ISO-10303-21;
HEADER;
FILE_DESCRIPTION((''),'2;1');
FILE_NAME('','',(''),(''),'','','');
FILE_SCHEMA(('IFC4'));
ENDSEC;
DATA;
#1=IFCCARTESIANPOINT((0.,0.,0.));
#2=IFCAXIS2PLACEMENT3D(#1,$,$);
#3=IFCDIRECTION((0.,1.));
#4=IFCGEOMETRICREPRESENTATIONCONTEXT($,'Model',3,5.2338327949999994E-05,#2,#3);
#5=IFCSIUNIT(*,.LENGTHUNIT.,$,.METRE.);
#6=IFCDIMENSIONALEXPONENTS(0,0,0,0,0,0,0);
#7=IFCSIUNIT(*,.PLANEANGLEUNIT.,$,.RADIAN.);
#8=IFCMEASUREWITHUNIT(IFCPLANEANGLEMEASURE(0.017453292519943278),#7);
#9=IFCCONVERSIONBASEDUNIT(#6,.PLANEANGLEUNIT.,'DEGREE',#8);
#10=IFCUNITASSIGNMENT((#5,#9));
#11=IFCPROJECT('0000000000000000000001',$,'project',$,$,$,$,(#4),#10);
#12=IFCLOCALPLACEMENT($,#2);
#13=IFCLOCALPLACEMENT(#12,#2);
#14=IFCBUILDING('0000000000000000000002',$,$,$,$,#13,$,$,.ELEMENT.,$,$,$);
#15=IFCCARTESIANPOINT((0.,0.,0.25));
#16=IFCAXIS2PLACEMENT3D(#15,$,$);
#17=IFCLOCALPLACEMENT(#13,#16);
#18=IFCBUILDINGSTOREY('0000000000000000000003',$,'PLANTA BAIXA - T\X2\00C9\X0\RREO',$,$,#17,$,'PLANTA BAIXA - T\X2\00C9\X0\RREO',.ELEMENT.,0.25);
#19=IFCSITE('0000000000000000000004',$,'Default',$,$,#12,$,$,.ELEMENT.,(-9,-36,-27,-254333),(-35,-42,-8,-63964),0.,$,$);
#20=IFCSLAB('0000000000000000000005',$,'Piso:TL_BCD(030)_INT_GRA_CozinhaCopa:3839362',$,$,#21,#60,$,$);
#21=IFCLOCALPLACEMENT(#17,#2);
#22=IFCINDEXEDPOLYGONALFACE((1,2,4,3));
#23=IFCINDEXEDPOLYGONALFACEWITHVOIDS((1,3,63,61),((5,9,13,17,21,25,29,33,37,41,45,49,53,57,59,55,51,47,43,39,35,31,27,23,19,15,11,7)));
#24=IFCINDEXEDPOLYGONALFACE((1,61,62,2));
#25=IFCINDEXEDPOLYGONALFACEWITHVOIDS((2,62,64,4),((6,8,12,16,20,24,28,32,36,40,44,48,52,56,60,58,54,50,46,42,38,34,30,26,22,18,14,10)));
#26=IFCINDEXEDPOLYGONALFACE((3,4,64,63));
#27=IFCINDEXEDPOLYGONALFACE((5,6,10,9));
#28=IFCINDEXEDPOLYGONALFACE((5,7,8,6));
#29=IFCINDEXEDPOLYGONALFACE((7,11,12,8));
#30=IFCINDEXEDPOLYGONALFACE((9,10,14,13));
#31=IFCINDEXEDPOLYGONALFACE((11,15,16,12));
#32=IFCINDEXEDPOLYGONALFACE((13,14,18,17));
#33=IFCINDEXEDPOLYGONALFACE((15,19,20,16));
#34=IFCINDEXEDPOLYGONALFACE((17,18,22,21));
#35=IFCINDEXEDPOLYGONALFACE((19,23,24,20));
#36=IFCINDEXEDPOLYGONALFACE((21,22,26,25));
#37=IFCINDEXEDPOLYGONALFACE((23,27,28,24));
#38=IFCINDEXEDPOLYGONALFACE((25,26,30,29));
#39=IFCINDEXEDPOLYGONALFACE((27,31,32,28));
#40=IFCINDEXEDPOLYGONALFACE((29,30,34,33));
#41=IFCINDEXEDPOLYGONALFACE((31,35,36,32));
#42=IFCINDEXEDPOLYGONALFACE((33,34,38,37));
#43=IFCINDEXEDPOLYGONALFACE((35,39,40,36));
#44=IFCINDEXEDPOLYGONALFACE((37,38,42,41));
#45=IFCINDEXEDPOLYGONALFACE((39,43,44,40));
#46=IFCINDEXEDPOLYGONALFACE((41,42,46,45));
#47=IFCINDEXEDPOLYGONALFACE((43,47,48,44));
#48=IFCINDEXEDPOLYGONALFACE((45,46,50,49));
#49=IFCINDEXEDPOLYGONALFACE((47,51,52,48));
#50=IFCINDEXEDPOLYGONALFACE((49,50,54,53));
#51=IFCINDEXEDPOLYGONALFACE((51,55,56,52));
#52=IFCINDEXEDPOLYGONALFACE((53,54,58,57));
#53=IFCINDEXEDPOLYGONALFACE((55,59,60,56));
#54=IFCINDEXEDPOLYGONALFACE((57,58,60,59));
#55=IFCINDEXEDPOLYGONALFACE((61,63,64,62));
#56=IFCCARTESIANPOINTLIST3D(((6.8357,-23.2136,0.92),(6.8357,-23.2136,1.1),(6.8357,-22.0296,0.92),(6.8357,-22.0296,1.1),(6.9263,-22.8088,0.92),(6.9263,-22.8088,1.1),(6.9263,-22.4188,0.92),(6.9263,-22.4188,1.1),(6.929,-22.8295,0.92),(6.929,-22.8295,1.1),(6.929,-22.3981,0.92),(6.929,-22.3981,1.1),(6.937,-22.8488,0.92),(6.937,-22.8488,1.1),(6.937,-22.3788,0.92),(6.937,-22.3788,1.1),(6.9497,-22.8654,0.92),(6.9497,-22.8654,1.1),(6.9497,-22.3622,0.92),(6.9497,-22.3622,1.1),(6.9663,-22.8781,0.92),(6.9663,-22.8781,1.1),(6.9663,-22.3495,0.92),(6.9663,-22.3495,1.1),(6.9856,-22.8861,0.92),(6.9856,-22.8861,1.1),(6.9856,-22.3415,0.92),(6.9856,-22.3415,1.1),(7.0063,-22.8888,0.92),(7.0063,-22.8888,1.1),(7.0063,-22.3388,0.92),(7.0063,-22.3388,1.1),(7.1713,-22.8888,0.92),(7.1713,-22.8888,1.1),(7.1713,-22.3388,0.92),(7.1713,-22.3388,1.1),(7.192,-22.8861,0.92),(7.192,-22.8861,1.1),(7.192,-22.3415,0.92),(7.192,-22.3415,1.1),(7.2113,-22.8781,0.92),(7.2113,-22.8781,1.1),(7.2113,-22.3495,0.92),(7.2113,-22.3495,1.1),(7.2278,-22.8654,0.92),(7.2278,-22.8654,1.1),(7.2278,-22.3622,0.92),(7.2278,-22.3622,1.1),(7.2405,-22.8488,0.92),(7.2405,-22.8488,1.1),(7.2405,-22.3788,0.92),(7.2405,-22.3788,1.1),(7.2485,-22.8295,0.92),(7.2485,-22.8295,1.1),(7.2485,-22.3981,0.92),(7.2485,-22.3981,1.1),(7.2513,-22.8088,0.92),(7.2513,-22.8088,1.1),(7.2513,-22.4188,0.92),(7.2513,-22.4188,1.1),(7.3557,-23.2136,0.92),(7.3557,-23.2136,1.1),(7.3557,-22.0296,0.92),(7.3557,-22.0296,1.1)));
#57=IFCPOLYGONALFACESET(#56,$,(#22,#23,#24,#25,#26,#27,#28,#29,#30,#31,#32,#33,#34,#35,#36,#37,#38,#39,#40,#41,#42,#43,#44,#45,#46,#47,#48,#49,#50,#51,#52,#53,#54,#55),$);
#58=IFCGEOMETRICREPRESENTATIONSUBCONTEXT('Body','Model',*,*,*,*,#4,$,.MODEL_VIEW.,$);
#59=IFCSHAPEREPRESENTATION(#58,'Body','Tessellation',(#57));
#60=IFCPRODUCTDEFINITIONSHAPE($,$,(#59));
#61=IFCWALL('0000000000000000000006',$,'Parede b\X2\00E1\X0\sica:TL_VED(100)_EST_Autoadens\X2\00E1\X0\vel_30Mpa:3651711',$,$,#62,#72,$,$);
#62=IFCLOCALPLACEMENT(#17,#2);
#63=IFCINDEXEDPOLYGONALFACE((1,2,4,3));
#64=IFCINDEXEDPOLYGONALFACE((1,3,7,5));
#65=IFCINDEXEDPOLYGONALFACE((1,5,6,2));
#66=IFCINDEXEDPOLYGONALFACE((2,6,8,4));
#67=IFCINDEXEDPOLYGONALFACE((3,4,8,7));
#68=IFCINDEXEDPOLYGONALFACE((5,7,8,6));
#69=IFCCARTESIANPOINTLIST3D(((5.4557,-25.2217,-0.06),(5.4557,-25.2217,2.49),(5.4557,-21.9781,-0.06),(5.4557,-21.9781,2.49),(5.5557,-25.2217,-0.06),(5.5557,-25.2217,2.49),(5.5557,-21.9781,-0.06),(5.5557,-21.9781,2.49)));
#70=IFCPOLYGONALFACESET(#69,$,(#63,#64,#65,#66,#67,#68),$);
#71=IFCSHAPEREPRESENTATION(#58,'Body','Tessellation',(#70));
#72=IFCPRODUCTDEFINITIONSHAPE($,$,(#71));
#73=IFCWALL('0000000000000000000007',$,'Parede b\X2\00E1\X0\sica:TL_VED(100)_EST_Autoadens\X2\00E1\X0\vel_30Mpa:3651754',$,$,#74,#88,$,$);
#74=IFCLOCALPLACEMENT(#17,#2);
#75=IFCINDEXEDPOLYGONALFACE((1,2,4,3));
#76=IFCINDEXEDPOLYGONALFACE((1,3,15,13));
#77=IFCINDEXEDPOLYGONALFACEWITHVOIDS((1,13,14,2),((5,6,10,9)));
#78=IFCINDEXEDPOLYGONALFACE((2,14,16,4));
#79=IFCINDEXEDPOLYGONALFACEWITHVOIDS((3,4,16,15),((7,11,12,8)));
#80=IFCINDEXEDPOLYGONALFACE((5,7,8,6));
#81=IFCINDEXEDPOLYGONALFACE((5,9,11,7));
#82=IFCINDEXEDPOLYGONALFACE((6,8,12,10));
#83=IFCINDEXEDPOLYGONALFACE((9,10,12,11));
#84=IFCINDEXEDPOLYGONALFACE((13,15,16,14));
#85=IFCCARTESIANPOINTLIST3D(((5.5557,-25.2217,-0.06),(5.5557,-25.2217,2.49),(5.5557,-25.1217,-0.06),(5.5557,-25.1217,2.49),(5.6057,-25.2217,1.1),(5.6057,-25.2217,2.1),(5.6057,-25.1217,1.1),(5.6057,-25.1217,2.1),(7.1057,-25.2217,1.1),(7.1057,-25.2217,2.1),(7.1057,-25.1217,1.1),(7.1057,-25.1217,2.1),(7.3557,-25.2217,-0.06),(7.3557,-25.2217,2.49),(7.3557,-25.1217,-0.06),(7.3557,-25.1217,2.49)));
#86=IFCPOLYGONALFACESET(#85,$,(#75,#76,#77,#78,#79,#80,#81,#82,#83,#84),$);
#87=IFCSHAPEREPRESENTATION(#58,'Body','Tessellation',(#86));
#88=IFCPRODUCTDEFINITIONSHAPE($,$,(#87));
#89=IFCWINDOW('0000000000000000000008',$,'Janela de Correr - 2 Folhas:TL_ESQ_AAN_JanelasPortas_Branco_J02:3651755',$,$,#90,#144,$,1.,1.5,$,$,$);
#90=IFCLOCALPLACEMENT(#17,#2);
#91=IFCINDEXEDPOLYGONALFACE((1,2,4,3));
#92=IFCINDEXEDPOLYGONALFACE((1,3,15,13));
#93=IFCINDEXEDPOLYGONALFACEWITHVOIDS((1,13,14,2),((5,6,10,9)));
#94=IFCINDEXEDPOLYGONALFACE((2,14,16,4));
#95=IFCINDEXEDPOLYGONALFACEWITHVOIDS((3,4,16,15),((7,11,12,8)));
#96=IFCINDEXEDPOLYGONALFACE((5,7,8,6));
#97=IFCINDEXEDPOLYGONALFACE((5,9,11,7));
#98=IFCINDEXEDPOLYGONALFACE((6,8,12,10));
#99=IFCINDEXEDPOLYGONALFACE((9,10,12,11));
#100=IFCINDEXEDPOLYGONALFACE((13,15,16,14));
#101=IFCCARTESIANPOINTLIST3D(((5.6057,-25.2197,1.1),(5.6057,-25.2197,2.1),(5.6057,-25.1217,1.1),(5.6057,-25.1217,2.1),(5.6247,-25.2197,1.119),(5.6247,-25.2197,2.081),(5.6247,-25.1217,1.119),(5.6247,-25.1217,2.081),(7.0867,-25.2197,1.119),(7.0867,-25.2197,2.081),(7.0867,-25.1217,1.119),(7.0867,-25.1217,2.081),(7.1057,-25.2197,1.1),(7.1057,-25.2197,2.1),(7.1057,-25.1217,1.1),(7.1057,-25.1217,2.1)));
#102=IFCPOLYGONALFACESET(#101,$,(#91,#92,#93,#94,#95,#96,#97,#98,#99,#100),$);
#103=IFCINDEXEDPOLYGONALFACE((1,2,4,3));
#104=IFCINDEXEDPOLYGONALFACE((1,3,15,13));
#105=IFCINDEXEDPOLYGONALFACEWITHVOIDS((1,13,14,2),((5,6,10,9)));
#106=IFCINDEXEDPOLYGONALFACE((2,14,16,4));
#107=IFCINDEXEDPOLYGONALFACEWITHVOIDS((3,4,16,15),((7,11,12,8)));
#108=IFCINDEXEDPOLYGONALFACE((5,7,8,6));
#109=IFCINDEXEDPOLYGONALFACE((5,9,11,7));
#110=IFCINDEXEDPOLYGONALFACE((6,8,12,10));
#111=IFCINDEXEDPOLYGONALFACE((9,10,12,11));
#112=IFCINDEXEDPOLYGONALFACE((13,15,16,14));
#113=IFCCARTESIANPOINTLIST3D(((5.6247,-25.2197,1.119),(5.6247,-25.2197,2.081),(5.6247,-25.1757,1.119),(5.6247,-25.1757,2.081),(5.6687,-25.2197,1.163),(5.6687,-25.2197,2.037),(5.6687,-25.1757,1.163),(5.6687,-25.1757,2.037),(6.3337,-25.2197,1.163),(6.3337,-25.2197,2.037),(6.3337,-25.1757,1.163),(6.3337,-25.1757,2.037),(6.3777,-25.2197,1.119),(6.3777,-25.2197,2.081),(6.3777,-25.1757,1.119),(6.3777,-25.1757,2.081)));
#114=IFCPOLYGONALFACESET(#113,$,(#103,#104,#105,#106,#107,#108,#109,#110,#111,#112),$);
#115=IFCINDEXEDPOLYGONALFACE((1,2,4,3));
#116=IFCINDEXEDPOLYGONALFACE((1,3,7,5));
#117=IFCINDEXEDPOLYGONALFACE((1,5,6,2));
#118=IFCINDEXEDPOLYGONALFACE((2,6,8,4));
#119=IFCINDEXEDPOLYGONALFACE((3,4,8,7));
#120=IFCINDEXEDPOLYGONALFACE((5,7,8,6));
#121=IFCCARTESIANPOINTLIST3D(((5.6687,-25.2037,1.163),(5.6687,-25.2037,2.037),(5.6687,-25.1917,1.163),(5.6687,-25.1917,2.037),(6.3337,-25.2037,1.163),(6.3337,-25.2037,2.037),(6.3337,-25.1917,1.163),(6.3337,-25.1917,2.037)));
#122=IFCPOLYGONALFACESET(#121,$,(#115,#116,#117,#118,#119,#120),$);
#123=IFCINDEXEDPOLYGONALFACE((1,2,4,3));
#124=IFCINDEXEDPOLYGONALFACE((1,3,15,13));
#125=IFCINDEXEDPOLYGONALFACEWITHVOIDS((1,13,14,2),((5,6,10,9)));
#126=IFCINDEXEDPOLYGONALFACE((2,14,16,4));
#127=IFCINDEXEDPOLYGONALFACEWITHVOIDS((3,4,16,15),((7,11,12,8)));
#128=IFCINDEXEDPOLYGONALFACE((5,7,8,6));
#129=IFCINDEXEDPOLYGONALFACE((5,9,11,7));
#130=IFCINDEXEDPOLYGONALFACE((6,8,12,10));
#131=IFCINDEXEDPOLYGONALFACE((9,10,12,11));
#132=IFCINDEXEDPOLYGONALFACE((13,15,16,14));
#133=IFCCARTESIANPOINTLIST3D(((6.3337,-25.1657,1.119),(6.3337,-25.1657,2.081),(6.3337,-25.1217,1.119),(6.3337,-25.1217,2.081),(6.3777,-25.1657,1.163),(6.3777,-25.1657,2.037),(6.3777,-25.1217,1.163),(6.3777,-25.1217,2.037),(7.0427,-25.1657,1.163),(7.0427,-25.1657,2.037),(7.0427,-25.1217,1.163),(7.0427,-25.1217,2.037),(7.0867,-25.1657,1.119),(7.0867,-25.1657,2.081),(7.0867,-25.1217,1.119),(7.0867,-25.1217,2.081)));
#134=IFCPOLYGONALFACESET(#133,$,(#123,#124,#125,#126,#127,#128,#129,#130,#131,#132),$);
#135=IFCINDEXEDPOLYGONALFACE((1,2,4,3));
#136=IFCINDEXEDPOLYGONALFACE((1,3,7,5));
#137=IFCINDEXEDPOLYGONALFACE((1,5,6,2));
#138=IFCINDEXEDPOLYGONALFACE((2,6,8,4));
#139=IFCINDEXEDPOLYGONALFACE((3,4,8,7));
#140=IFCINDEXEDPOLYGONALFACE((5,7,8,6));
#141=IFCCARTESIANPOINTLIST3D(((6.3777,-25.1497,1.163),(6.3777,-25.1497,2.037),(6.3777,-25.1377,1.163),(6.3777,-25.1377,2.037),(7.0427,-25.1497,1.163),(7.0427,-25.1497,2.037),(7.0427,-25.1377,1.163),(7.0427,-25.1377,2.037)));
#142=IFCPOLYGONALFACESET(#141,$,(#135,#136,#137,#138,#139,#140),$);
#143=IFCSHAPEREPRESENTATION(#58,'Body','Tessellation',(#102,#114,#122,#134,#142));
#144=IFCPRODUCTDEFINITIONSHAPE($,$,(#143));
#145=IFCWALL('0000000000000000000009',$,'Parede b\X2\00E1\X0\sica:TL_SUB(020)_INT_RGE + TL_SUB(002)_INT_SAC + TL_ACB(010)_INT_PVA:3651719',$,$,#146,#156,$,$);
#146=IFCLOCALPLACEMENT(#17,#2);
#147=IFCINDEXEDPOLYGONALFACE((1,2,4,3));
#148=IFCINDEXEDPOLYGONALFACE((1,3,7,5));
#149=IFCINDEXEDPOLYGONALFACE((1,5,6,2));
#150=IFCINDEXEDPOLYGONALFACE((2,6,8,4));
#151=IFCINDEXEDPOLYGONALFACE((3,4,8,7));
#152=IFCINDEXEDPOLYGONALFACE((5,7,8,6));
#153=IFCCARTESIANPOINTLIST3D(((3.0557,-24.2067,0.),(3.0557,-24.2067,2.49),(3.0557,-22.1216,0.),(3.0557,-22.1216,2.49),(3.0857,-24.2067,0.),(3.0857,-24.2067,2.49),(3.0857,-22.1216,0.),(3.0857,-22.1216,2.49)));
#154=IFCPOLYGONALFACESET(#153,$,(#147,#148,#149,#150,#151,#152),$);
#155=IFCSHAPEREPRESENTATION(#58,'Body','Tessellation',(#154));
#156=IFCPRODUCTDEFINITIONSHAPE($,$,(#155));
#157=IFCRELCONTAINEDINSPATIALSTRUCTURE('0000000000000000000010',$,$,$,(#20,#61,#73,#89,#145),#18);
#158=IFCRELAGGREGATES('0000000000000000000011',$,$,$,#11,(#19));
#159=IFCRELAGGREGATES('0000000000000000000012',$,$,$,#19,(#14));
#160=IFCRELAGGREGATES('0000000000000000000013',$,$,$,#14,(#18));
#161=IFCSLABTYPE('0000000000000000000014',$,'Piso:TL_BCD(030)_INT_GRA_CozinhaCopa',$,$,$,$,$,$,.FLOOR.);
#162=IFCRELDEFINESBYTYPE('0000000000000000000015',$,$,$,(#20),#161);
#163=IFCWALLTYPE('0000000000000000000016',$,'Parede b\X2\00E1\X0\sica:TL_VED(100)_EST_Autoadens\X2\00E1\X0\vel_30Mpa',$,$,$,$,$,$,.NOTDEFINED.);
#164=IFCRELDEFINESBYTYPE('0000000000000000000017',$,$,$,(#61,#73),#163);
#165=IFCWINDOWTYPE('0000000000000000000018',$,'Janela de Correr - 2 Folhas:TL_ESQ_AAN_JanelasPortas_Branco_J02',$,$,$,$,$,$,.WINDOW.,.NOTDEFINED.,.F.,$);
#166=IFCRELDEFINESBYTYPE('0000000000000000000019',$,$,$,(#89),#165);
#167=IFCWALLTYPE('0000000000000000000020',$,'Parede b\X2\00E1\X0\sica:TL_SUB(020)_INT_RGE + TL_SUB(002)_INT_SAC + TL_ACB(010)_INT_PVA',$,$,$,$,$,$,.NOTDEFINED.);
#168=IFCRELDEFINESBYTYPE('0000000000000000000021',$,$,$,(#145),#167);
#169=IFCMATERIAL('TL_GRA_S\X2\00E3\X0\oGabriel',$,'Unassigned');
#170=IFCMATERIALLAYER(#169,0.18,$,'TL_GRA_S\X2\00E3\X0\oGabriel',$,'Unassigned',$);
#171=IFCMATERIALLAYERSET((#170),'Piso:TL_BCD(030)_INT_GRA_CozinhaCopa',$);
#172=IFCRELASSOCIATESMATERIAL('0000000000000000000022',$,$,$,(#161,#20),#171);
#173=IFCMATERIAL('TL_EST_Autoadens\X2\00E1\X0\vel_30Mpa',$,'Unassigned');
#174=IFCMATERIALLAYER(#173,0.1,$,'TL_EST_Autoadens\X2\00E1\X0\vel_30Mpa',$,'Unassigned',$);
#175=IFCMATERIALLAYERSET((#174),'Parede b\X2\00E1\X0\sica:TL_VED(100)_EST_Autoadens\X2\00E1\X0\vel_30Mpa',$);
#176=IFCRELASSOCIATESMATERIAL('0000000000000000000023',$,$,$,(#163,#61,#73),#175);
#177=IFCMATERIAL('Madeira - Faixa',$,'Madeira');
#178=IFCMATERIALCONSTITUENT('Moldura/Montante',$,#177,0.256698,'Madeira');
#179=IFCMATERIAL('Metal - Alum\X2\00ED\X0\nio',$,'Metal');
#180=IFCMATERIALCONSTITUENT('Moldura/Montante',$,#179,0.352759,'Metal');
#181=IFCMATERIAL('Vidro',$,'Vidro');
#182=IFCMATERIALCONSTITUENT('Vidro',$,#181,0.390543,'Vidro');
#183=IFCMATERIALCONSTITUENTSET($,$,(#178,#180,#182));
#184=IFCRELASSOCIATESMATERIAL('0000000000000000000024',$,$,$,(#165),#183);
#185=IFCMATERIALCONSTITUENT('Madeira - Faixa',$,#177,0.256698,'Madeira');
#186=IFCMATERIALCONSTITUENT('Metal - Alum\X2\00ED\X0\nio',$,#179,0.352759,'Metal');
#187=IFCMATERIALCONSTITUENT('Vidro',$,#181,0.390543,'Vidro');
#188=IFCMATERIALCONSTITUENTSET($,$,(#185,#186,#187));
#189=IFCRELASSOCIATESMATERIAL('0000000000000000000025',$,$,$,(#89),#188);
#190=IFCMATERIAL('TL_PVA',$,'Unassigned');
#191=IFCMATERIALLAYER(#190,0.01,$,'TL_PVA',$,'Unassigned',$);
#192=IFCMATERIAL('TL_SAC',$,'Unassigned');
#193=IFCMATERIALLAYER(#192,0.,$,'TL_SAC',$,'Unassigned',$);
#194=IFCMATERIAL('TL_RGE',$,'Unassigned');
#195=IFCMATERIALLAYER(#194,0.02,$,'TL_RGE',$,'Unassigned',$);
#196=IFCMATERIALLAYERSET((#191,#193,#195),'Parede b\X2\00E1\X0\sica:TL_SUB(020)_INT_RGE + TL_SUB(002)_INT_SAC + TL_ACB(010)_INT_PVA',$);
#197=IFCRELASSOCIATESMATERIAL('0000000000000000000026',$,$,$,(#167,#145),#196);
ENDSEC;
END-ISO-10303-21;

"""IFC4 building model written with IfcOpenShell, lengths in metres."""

from ifc_helpers import new_model, entity, si_unit, converted_unit, direction, frame, frame_2d, origin, origin_2d_with_axis, place, context, subcontext, project, spatial, polyline, circle_curve, parameter, trimmed, segment, composite_curve, rectangle, outline, extrude, source, transform, mapped, material, layer, layer_set, layer_usage, constituent, constituent_set, type_object, type_shapes, element, fill, save


model = new_model("IFC4")

# Units and contexts
model_context = context("Model", 3, precision=5.2338327949999994e-05, world=origin(), true_north=direction((0.0, 1.0)))
body_context = subcontext(model_context, "Body", "Model", "MODEL_VIEW")
ifc_project = project(units=[si_unit("LENGTHUNIT", "METRE"), converted_unit("PLANEANGLEUNIT", "DEGREE", entity("IfcPlaneAngleMeasure", 0.017453292519943278), si_unit("PLANEANGLEUNIT", "RADIAN"), dimensions=[0, 0, 0, 0, 0, 0, 0])], contexts=[model_context])

# Site, building, storey
site_placement = place(None, frame((0.0, 0.0, 0.0)))
site = spatial("IfcSite", under=ifc_project, at=site_placement, Name="Default", CompositionType="ELEMENT", RefLatitude=(-9, -36, -27, -254333), RefLongitude=(-35, -42, -8, -63964), RefElevation=0.0)
building_placement = place(site_placement, origin())
building = spatial("IfcBuilding", under=site, at=building_placement, CompositionType="ELEMENT")
storey_placement = place(building_placement, frame((0.0, 0.0, 0.25)))
storey = spatial("IfcBuildingStorey", under=building, at=storey_placement, Name="PLANTA BAIXA - TÉRREO", LongName="PLANTA BAIXA - TÉRREO", CompositionType="ELEMENT", Elevation=0.25)

# Slab, opening
ifc_material_1 = material(Name="TL_GRA_SãoGabriel", Category="Unassigned")
ifc_layer_1 = layer(ifc_material_1, 0.18, Name="TL_GRA_SãoGabriel", Category="Unassigned")
ifc_layer_set_1 = layer_set([ifc_layer_1], Name="Piso:TL_BCD(030)_INT_GRA_CozinhaCopa")
ifc_layer_usage_1 = layer_usage(ifc_layer_set_1, "AXIS3", "POSITIVE", 0.0)
slab_type = type_object("IfcSlabType", Name="Piso:TL_BCD(030)_INT_GRA_CozinhaCopa", PredefinedType="FLOOR", material=ifc_layer_set_1)
slab_placement = place(storey_placement, frame((6.8357, -23.2136, 0.92)))
slab = element("IfcSlab", 1, at=slab_placement, inside=storey, type_object=slab_type, material=ifc_layer_usage_1, Name="Piso:TL_BCD(030)_INT_GRA_CozinhaCopa:3839362", context=body_context, shape_type="SweptSolid", body=[
    extrude(rectangle(XDim=0.52, YDim=1.184, at=origin_2d_with_axis()), frame((0.26, 0.592, 0.18), z_axis=(0.0, 0.0, -1.0), x_axis=(-1.0, 0.0, 0.0)), (0.0, 0.0, 1.0), 0.18),
])
opening_1_placement = place(slab_placement, frame((-6.8357, 23.2136, 0.18)))
element("IfcOpeningElement", 2, at=opening_1_placement, cuts=slab, PredefinedType="OPENING", context=body_context, shape_type="SweptSolid", body=[
    extrude(outline(composite_curve([segment(trimmed(circle_curve(frame_2d((0.195, -0.0825), x_axis=(1.0, 0.0)), 0.08), [parameter(270.0)], [parameter(0.0)], True, "PARAMETER"), True, "CONTINUOUS"), segment(polyline([(0.275, -0.0825), (0.275, 0.0825)]), True, "CONTINUOUS"), segment(trimmed(circle_curve(frame_2d((0.195, 0.0825), x_axis=(1.0, 0.0)), 0.08), [parameter(0.0)], [parameter(90.0)], True, "PARAMETER"), True, "CONTINUOUS"), segment(polyline([(0.195, 0.1625), (-0.195, 0.1625)]), True, "CONTINUOUS"), segment(trimmed(circle_curve(frame_2d((-0.195, 0.0825), x_axis=(1.0, 0.0)), 0.08), [parameter(90.0)], [parameter(180.0)], True, "PARAMETER"), True, "CONTINUOUS"), segment(polyline([(-0.275, 0.0825), (-0.275, -0.0825)]), True, "CONTINUOUS"), segment(trimmed(circle_curve(frame_2d((-0.195, -0.0825), x_axis=(1.0, 0.0)), 0.08), [parameter(180.0)], [parameter(270.0)], True, "PARAMETER"), True, "CONTINUOUS"), segment(polyline([(-0.195, -0.1625), (0.195, -0.1625)]), True, "CONTINUOUS")], self_intersect=False)), frame((7.0888, -22.6138, -0.21), z_axis=(0.0, 0.0, 1.0), x_axis=(0.0, 1.0, 0.0)), (0.0, 0.0, 1.0), 0.21),
])

# Wall
ifc_material_2 = material(Name="TL_EST_Autoadensável_30Mpa", Category="Unassigned")
ifc_layer_2 = layer(ifc_material_2, 0.1, Name="TL_EST_Autoadensável_30Mpa", Category="Unassigned")
ifc_layer_set_2 = layer_set([ifc_layer_2], Name="Parede básica:TL_VED(100)_EST_Autoadensável_30Mpa")
ifc_layer_usage_2 = layer_usage(ifc_layer_set_2, "AXIS2", "POSITIVE", -0.05)
wall_type_1 = type_object("IfcWallType", Name="Parede básica:TL_VED(100)_EST_Autoadensável_30Mpa", PredefinedType="NOTDEFINED", material=ifc_layer_set_2)
wall_1_placement = place(storey_placement, frame((5.5057, -25.2217, -0.06), z_axis=(0.0, 0.0, 1.0), x_axis=(0.0, 1.0, 0.0)))
element("IfcWall", 3, at=wall_1_placement, inside=storey, type_object=wall_type_1, material=ifc_layer_usage_2, Name="Parede básica:TL_VED(100)_EST_Autoadensável_30Mpa:3651711", context=body_context, shape_type="SweptSolid", body=[
    extrude(rectangle(XDim=3.2437, YDim=0.1, at=frame_2d((1.6218, 0.0), x_axis=(-1.0, 0.0))), origin(), (0.0, 0.0, 1.0), 2.55),
])

# Wall, opening, window
ifc_layer_usage_3 = layer_usage(ifc_layer_set_2, "AXIS2", "POSITIVE", -0.05)
wall_2_placement = place(storey_placement, frame((5.5557, -25.1717, -0.06)))
wall_2 = element("IfcWall", 4, at=wall_2_placement, inside=storey, type_object=wall_type_1, material=ifc_layer_usage_3, Name="Parede básica:TL_VED(100)_EST_Autoadensável_30Mpa:3651754", context=body_context, shape_type="SweptSolid", body=[
    extrude(rectangle(XDim=1.8, YDim=0.1, at=frame_2d((0.9, 0.0), x_axis=(-1.0, 0.0))), origin(), (0.0, 0.0, 1.0), 2.55),
])
opening_2_placement = place(wall_2_placement, frame((1.55, 0.05, 1.16)))
opening_2 = element("IfcOpeningElement", 5, at=opening_2_placement, cuts=wall_2, PredefinedType="OPENING", context=body_context, shape_type="SweptSolid", body=[
    extrude(rectangle(XDim=1.0, YDim=1.5, at=frame_2d((0.5, 0.75), x_axis=(-1.0, 0.0))), frame((0.0, 0.0, 0.0), z_axis=(0.0, -1.0, 0.0), x_axis=(0.0, 0.0, 1.0)), (0.0, 0.0, 1.0), 0.1),
])
ifc_material_3 = material(Name="Madeira - Faixa", Category="Madeira")
ifc_constituent_1 = constituent(ifc_material_3, Name="Madeira - Faixa", Category="Madeira", fraction=0.256698)
ifc_material_4 = material(Name="Metal - Alumínio", Category="Metal")
ifc_constituent_2 = constituent(ifc_material_4, Name="Metal - Alumínio", Category="Metal", fraction=0.352759)
ifc_material_5 = material(Name="Vidro", Category="Vidro")
ifc_constituent_3 = constituent(ifc_material_5, Name="Vidro", Category="Vidro", fraction=0.390543)
ifc_constituent_set_1 = constituent_set(constituents=[ifc_constituent_1, ifc_constituent_2, ifc_constituent_3])
ifc_constituent_4 = constituent(ifc_material_3, Name="Moldura/Montante", Category="Madeira", fraction=0.256698)
ifc_constituent_5 = constituent(ifc_material_4, Name="Moldura/Montante", Category="Metal", fraction=0.352759)
ifc_constituent_6 = constituent(ifc_material_5, Name="Vidro", Category="Vidro", fraction=0.390543)
ifc_constituent_set_2 = constituent_set(constituents=[ifc_constituent_4, ifc_constituent_5, ifc_constituent_6])
window_type = type_object("IfcWindowType", Name="Janela de Correr - 2 Folhas:TL_ESQ_AAN_JanelasPortas_Branco_J02", ParameterTakesPrecedence=False, PartitioningType="NOTDEFINED", PredefinedType="WINDOW", material=ifc_constituent_set_2)
shared_shape_1 = source(origin(), body_context, "Body", "SweptSolid", [
    extrude(outline(polyline([(-0.75, -0.5), (0.75, -0.5), (0.75, 0.5), (-0.75, 0.5), (-0.75, -0.5)]), holes=[polyline([(-0.731, -0.481), (-0.731, 0.481), (0.731, 0.481), (0.731, -0.481), (-0.731, -0.481)])]), frame((0.75, 0.0, 0.5), z_axis=(0.0, 1.0, 0.0), x_axis=(1.0, 0.0, 0.0)), (0.0, 0.0, 1.0), 0.098),
    extrude(outline(polyline([(-0.3765, -0.481), (0.3765, -0.481), (0.3765, 0.481), (-0.3765, 0.481), (-0.3765, -0.481)]), holes=[polyline([(-0.3325, -0.437), (-0.3325, 0.437), (0.3325, 0.437), (0.3325, -0.437), (-0.3325, -0.437)])]), frame((1.1045, 0.054, 0.5), z_axis=(0.0, 1.0, 0.0), x_axis=(1.0, 0.0, 0.0)), (0.0, 0.0, 1.0), 0.044),
    extrude(rectangle(XDim=0.012, YDim=0.665, at=origin_2d_with_axis()), frame((1.1045, 0.076, 0.063), z_axis=(0.0, 0.0, 1.0), x_axis=(0.0, -1.0, 0.0)), (0.0, 0.0, 1.0), 0.874),
    extrude(outline(polyline([(-0.481, -0.3765), (0.481, -0.3765), (0.481, 0.3765), (-0.481, 0.3765), (-0.481, -0.3765)]), holes=[polyline([(-0.437, -0.3325), (-0.437, 0.3325), (0.437, 0.3325), (0.437, -0.3325), (-0.437, -0.3325)])]), frame((0.3955, 0.0, 0.5), z_axis=(0.0, 1.0, 0.0), x_axis=(0.0, 0.0, -1.0)), (0.0, 0.0, 1.0), 0.044),
    extrude(rectangle(XDim=0.012, YDim=0.665, at=origin_2d_with_axis()), frame((0.3955, 0.022, 0.063), z_axis=(0.0, 0.0, 1.0), x_axis=(0.0, -1.0, 0.0)), (0.0, 0.0, 1.0), 0.874),
])
type_shapes(window_type, [shared_shape_1])
window_placement = place(opening_2_placement, frame((0.0, 0.0, 0.0), z_axis=(0.0, 0.0, 1.0), x_axis=(-1.0, 0.0, 0.0)))
window = element("IfcWindow", 6, at=window_placement, inside=storey, type_object=window_type, material=ifc_constituent_set_1, Name="Janela de Correr - 2 Folhas:TL_ESQ_AAN_JanelasPortas_Branco_J02:3651755", OverallHeight=1.0, OverallWidth=1.5, context=body_context, shape_type="MappedRepresentation", body=[
    mapped(shared_shape_1, transform((0.0, 0.0, 0.0), scale=1.0)),
])
fill(opening_2, window)

# Wall
ifc_material_6 = material(Name="TL_PVA", Category="Unassigned")
ifc_layer_3 = layer(ifc_material_6, 0.01, Name="TL_PVA", Category="Unassigned")
ifc_material_7 = material(Name="TL_SAC", Category="Unassigned")
ifc_layer_4 = layer(ifc_material_7, 0.0, Name="TL_SAC", Category="Unassigned")
ifc_material_8 = material(Name="TL_RGE", Category="Unassigned")
ifc_layer_5 = layer(ifc_material_8, 0.02, Name="TL_RGE", Category="Unassigned")
ifc_layer_set_3 = layer_set([ifc_layer_3, ifc_layer_4, ifc_layer_5], Name="Parede básica:TL_SUB(020)_INT_RGE + TL_SUB(002)_INT_SAC + TL_ACB(010)_INT_PVA")
ifc_layer_usage_4 = layer_usage(ifc_layer_set_3, "AXIS2", "POSITIVE", -0.015)
wall_type_2 = type_object("IfcWallType", Name="Parede básica:TL_SUB(020)_INT_RGE + TL_SUB(002)_INT_SAC + TL_ACB(010)_INT_PVA", PredefinedType="NOTDEFINED", material=ifc_layer_set_3)
wall_3_placement = place(storey_placement, frame((3.0707, -24.2067, 0.0), z_axis=(0.0, 0.0, 1.0), x_axis=(0.0, 1.0, 0.0)))
element("IfcWall", 7, at=wall_3_placement, inside=storey, type_object=wall_type_2, material=ifc_layer_usage_4, Name="Parede básica:TL_SUB(020)_INT_RGE + TL_SUB(002)_INT_SAC + TL_ACB(010)_INT_PVA:3651719", context=body_context, shape_type="SweptSolid", body=[
    extrude(rectangle(XDim=2.0851, YDim=0.03, at=frame_2d((1.0426, 0.0), x_axis=(-1.0, 0.0))), origin(), (0.0, 0.0, 1.0), 2.49),
])

save(model, "model.ifc")
